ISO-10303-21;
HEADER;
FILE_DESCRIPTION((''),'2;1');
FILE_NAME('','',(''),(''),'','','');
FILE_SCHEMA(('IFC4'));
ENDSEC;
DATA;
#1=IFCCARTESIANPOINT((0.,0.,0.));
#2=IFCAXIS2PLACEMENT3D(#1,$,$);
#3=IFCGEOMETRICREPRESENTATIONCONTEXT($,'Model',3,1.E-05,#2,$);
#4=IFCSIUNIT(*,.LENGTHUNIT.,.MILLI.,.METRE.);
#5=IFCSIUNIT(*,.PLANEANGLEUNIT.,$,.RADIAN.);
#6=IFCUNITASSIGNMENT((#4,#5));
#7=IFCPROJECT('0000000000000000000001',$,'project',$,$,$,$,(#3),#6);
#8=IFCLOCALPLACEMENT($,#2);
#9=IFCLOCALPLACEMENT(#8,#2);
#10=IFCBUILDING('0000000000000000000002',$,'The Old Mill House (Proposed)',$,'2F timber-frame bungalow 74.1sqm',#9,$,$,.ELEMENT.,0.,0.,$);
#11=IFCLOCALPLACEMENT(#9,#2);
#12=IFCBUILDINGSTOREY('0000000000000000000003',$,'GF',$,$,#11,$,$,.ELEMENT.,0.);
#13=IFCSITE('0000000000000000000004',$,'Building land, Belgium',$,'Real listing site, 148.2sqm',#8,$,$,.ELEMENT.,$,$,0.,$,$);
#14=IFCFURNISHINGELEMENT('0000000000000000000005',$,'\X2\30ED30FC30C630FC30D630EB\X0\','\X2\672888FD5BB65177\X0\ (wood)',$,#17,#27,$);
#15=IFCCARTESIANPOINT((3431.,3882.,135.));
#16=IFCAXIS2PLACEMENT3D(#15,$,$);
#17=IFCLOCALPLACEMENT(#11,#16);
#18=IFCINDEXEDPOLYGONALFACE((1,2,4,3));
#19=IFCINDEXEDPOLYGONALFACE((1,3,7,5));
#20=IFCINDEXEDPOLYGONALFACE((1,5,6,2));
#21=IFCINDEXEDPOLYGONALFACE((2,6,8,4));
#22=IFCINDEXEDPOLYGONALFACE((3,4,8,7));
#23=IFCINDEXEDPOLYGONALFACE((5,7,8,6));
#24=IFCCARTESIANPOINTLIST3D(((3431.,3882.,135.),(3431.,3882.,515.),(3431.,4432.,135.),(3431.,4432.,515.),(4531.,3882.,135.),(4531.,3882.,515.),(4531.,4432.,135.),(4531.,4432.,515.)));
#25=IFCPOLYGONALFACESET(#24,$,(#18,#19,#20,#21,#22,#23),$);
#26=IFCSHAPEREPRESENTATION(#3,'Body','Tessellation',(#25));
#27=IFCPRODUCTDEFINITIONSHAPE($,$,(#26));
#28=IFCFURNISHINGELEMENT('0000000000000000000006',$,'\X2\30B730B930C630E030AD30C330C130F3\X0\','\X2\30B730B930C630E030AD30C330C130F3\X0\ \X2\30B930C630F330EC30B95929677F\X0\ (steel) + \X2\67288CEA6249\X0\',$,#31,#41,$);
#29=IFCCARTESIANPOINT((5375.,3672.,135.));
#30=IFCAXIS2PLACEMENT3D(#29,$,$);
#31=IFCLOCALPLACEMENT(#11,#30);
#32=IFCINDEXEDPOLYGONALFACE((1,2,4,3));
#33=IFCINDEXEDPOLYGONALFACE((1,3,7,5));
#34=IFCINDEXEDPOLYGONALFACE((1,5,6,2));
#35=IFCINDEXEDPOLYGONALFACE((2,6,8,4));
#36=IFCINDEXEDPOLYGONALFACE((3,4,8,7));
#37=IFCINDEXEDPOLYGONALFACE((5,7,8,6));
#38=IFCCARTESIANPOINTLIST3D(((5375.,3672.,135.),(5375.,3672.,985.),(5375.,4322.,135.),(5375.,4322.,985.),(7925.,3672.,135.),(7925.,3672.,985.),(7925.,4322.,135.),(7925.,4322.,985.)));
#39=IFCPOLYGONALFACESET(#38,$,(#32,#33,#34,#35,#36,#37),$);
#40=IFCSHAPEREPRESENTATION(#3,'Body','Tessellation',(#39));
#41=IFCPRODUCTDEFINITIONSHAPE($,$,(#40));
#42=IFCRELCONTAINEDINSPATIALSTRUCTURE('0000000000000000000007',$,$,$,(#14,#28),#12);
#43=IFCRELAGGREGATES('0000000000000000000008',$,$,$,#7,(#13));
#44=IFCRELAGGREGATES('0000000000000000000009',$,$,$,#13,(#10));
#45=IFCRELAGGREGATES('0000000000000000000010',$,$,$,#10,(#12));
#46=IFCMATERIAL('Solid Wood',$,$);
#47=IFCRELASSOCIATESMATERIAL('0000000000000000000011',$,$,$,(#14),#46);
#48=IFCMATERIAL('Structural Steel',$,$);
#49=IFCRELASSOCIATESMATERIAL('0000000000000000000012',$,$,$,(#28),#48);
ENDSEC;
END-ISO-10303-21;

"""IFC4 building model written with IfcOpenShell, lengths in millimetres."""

from ifc_helpers import new_model, si_unit, frame, frame_2d, origin, place, context, project, spatial, rectangle, extrude, material, element, save


model = new_model("IFC4")

# Units and contexts
model_context = context("Model", 3, precision=1e-05, world=origin())
ifc_project = project(units=[si_unit("LENGTHUNIT", "METRE", prefix="MILLI"), si_unit("PLANEANGLEUNIT", "RADIAN")], contexts=[model_context])

# Site, building, storey
site_placement = place(None, origin())
site = spatial("IfcSite", under=ifc_project, at=site_placement, Name="Building land, Belgium", ObjectType="Real listing site, 148.2sqm", CompositionType="ELEMENT", RefElevation=0.0)
building_placement = place(site_placement, origin())
building = spatial("IfcBuilding", under=site, at=building_placement, Name="The Old Mill House (Proposed)", ObjectType="2F timber-frame bungalow 74.1sqm", CompositionType="ELEMENT", ElevationOfRefHeight=0.0, ElevationOfTerrain=0.0)
storey_placement = place(building_placement, origin())
storey = spatial("IfcBuildingStorey", under=building, at=storey_placement, Name="GF", CompositionType="ELEMENT", Elevation=0.0)

# Shared definitions
ifc_material_1 = material(Name="Solid Wood")

# Furnishing elements
furnishing_1_placement = place(storey_placement, frame((3431.0, 3882.0, 135.0)))
element("IfcFurnishingElement", 1, at=furnishing_1_placement, inside=storey, material=ifc_material_1, Name="ローテーブル", Description="木製家具 (wood)", context=model_context, shape_type="SweptSolid", body=[
    extrude(rectangle(XDim=1100.0, YDim=550.0, at=frame_2d((550.0, 275.0))), frame((3431.0, 3882.0, 135.0)), (0.0, 0.0, 1.0), 380.0),
])
ifc_material_2 = material(Name="Structural Steel")
furnishing_2_placement = place(storey_placement, frame((5375.0, 3672.0, 135.0)))
element("IfcFurnishingElement", 2, at=furnishing_2_placement, inside=storey, material=ifc_material_2, Name="システムキッチン", Description="システムキッチン ステンレス天板 (steel) + 木質扉", context=model_context, shape_type="SweptSolid", body=[
    extrude(rectangle(XDim=2550.0, YDim=650.0, at=frame_2d((1275.0, 325.0))), frame((5375.0, 3672.0, 135.0)), (0.0, 0.0, 1.0), 850.0),
])

save(model, "model.ifc")
